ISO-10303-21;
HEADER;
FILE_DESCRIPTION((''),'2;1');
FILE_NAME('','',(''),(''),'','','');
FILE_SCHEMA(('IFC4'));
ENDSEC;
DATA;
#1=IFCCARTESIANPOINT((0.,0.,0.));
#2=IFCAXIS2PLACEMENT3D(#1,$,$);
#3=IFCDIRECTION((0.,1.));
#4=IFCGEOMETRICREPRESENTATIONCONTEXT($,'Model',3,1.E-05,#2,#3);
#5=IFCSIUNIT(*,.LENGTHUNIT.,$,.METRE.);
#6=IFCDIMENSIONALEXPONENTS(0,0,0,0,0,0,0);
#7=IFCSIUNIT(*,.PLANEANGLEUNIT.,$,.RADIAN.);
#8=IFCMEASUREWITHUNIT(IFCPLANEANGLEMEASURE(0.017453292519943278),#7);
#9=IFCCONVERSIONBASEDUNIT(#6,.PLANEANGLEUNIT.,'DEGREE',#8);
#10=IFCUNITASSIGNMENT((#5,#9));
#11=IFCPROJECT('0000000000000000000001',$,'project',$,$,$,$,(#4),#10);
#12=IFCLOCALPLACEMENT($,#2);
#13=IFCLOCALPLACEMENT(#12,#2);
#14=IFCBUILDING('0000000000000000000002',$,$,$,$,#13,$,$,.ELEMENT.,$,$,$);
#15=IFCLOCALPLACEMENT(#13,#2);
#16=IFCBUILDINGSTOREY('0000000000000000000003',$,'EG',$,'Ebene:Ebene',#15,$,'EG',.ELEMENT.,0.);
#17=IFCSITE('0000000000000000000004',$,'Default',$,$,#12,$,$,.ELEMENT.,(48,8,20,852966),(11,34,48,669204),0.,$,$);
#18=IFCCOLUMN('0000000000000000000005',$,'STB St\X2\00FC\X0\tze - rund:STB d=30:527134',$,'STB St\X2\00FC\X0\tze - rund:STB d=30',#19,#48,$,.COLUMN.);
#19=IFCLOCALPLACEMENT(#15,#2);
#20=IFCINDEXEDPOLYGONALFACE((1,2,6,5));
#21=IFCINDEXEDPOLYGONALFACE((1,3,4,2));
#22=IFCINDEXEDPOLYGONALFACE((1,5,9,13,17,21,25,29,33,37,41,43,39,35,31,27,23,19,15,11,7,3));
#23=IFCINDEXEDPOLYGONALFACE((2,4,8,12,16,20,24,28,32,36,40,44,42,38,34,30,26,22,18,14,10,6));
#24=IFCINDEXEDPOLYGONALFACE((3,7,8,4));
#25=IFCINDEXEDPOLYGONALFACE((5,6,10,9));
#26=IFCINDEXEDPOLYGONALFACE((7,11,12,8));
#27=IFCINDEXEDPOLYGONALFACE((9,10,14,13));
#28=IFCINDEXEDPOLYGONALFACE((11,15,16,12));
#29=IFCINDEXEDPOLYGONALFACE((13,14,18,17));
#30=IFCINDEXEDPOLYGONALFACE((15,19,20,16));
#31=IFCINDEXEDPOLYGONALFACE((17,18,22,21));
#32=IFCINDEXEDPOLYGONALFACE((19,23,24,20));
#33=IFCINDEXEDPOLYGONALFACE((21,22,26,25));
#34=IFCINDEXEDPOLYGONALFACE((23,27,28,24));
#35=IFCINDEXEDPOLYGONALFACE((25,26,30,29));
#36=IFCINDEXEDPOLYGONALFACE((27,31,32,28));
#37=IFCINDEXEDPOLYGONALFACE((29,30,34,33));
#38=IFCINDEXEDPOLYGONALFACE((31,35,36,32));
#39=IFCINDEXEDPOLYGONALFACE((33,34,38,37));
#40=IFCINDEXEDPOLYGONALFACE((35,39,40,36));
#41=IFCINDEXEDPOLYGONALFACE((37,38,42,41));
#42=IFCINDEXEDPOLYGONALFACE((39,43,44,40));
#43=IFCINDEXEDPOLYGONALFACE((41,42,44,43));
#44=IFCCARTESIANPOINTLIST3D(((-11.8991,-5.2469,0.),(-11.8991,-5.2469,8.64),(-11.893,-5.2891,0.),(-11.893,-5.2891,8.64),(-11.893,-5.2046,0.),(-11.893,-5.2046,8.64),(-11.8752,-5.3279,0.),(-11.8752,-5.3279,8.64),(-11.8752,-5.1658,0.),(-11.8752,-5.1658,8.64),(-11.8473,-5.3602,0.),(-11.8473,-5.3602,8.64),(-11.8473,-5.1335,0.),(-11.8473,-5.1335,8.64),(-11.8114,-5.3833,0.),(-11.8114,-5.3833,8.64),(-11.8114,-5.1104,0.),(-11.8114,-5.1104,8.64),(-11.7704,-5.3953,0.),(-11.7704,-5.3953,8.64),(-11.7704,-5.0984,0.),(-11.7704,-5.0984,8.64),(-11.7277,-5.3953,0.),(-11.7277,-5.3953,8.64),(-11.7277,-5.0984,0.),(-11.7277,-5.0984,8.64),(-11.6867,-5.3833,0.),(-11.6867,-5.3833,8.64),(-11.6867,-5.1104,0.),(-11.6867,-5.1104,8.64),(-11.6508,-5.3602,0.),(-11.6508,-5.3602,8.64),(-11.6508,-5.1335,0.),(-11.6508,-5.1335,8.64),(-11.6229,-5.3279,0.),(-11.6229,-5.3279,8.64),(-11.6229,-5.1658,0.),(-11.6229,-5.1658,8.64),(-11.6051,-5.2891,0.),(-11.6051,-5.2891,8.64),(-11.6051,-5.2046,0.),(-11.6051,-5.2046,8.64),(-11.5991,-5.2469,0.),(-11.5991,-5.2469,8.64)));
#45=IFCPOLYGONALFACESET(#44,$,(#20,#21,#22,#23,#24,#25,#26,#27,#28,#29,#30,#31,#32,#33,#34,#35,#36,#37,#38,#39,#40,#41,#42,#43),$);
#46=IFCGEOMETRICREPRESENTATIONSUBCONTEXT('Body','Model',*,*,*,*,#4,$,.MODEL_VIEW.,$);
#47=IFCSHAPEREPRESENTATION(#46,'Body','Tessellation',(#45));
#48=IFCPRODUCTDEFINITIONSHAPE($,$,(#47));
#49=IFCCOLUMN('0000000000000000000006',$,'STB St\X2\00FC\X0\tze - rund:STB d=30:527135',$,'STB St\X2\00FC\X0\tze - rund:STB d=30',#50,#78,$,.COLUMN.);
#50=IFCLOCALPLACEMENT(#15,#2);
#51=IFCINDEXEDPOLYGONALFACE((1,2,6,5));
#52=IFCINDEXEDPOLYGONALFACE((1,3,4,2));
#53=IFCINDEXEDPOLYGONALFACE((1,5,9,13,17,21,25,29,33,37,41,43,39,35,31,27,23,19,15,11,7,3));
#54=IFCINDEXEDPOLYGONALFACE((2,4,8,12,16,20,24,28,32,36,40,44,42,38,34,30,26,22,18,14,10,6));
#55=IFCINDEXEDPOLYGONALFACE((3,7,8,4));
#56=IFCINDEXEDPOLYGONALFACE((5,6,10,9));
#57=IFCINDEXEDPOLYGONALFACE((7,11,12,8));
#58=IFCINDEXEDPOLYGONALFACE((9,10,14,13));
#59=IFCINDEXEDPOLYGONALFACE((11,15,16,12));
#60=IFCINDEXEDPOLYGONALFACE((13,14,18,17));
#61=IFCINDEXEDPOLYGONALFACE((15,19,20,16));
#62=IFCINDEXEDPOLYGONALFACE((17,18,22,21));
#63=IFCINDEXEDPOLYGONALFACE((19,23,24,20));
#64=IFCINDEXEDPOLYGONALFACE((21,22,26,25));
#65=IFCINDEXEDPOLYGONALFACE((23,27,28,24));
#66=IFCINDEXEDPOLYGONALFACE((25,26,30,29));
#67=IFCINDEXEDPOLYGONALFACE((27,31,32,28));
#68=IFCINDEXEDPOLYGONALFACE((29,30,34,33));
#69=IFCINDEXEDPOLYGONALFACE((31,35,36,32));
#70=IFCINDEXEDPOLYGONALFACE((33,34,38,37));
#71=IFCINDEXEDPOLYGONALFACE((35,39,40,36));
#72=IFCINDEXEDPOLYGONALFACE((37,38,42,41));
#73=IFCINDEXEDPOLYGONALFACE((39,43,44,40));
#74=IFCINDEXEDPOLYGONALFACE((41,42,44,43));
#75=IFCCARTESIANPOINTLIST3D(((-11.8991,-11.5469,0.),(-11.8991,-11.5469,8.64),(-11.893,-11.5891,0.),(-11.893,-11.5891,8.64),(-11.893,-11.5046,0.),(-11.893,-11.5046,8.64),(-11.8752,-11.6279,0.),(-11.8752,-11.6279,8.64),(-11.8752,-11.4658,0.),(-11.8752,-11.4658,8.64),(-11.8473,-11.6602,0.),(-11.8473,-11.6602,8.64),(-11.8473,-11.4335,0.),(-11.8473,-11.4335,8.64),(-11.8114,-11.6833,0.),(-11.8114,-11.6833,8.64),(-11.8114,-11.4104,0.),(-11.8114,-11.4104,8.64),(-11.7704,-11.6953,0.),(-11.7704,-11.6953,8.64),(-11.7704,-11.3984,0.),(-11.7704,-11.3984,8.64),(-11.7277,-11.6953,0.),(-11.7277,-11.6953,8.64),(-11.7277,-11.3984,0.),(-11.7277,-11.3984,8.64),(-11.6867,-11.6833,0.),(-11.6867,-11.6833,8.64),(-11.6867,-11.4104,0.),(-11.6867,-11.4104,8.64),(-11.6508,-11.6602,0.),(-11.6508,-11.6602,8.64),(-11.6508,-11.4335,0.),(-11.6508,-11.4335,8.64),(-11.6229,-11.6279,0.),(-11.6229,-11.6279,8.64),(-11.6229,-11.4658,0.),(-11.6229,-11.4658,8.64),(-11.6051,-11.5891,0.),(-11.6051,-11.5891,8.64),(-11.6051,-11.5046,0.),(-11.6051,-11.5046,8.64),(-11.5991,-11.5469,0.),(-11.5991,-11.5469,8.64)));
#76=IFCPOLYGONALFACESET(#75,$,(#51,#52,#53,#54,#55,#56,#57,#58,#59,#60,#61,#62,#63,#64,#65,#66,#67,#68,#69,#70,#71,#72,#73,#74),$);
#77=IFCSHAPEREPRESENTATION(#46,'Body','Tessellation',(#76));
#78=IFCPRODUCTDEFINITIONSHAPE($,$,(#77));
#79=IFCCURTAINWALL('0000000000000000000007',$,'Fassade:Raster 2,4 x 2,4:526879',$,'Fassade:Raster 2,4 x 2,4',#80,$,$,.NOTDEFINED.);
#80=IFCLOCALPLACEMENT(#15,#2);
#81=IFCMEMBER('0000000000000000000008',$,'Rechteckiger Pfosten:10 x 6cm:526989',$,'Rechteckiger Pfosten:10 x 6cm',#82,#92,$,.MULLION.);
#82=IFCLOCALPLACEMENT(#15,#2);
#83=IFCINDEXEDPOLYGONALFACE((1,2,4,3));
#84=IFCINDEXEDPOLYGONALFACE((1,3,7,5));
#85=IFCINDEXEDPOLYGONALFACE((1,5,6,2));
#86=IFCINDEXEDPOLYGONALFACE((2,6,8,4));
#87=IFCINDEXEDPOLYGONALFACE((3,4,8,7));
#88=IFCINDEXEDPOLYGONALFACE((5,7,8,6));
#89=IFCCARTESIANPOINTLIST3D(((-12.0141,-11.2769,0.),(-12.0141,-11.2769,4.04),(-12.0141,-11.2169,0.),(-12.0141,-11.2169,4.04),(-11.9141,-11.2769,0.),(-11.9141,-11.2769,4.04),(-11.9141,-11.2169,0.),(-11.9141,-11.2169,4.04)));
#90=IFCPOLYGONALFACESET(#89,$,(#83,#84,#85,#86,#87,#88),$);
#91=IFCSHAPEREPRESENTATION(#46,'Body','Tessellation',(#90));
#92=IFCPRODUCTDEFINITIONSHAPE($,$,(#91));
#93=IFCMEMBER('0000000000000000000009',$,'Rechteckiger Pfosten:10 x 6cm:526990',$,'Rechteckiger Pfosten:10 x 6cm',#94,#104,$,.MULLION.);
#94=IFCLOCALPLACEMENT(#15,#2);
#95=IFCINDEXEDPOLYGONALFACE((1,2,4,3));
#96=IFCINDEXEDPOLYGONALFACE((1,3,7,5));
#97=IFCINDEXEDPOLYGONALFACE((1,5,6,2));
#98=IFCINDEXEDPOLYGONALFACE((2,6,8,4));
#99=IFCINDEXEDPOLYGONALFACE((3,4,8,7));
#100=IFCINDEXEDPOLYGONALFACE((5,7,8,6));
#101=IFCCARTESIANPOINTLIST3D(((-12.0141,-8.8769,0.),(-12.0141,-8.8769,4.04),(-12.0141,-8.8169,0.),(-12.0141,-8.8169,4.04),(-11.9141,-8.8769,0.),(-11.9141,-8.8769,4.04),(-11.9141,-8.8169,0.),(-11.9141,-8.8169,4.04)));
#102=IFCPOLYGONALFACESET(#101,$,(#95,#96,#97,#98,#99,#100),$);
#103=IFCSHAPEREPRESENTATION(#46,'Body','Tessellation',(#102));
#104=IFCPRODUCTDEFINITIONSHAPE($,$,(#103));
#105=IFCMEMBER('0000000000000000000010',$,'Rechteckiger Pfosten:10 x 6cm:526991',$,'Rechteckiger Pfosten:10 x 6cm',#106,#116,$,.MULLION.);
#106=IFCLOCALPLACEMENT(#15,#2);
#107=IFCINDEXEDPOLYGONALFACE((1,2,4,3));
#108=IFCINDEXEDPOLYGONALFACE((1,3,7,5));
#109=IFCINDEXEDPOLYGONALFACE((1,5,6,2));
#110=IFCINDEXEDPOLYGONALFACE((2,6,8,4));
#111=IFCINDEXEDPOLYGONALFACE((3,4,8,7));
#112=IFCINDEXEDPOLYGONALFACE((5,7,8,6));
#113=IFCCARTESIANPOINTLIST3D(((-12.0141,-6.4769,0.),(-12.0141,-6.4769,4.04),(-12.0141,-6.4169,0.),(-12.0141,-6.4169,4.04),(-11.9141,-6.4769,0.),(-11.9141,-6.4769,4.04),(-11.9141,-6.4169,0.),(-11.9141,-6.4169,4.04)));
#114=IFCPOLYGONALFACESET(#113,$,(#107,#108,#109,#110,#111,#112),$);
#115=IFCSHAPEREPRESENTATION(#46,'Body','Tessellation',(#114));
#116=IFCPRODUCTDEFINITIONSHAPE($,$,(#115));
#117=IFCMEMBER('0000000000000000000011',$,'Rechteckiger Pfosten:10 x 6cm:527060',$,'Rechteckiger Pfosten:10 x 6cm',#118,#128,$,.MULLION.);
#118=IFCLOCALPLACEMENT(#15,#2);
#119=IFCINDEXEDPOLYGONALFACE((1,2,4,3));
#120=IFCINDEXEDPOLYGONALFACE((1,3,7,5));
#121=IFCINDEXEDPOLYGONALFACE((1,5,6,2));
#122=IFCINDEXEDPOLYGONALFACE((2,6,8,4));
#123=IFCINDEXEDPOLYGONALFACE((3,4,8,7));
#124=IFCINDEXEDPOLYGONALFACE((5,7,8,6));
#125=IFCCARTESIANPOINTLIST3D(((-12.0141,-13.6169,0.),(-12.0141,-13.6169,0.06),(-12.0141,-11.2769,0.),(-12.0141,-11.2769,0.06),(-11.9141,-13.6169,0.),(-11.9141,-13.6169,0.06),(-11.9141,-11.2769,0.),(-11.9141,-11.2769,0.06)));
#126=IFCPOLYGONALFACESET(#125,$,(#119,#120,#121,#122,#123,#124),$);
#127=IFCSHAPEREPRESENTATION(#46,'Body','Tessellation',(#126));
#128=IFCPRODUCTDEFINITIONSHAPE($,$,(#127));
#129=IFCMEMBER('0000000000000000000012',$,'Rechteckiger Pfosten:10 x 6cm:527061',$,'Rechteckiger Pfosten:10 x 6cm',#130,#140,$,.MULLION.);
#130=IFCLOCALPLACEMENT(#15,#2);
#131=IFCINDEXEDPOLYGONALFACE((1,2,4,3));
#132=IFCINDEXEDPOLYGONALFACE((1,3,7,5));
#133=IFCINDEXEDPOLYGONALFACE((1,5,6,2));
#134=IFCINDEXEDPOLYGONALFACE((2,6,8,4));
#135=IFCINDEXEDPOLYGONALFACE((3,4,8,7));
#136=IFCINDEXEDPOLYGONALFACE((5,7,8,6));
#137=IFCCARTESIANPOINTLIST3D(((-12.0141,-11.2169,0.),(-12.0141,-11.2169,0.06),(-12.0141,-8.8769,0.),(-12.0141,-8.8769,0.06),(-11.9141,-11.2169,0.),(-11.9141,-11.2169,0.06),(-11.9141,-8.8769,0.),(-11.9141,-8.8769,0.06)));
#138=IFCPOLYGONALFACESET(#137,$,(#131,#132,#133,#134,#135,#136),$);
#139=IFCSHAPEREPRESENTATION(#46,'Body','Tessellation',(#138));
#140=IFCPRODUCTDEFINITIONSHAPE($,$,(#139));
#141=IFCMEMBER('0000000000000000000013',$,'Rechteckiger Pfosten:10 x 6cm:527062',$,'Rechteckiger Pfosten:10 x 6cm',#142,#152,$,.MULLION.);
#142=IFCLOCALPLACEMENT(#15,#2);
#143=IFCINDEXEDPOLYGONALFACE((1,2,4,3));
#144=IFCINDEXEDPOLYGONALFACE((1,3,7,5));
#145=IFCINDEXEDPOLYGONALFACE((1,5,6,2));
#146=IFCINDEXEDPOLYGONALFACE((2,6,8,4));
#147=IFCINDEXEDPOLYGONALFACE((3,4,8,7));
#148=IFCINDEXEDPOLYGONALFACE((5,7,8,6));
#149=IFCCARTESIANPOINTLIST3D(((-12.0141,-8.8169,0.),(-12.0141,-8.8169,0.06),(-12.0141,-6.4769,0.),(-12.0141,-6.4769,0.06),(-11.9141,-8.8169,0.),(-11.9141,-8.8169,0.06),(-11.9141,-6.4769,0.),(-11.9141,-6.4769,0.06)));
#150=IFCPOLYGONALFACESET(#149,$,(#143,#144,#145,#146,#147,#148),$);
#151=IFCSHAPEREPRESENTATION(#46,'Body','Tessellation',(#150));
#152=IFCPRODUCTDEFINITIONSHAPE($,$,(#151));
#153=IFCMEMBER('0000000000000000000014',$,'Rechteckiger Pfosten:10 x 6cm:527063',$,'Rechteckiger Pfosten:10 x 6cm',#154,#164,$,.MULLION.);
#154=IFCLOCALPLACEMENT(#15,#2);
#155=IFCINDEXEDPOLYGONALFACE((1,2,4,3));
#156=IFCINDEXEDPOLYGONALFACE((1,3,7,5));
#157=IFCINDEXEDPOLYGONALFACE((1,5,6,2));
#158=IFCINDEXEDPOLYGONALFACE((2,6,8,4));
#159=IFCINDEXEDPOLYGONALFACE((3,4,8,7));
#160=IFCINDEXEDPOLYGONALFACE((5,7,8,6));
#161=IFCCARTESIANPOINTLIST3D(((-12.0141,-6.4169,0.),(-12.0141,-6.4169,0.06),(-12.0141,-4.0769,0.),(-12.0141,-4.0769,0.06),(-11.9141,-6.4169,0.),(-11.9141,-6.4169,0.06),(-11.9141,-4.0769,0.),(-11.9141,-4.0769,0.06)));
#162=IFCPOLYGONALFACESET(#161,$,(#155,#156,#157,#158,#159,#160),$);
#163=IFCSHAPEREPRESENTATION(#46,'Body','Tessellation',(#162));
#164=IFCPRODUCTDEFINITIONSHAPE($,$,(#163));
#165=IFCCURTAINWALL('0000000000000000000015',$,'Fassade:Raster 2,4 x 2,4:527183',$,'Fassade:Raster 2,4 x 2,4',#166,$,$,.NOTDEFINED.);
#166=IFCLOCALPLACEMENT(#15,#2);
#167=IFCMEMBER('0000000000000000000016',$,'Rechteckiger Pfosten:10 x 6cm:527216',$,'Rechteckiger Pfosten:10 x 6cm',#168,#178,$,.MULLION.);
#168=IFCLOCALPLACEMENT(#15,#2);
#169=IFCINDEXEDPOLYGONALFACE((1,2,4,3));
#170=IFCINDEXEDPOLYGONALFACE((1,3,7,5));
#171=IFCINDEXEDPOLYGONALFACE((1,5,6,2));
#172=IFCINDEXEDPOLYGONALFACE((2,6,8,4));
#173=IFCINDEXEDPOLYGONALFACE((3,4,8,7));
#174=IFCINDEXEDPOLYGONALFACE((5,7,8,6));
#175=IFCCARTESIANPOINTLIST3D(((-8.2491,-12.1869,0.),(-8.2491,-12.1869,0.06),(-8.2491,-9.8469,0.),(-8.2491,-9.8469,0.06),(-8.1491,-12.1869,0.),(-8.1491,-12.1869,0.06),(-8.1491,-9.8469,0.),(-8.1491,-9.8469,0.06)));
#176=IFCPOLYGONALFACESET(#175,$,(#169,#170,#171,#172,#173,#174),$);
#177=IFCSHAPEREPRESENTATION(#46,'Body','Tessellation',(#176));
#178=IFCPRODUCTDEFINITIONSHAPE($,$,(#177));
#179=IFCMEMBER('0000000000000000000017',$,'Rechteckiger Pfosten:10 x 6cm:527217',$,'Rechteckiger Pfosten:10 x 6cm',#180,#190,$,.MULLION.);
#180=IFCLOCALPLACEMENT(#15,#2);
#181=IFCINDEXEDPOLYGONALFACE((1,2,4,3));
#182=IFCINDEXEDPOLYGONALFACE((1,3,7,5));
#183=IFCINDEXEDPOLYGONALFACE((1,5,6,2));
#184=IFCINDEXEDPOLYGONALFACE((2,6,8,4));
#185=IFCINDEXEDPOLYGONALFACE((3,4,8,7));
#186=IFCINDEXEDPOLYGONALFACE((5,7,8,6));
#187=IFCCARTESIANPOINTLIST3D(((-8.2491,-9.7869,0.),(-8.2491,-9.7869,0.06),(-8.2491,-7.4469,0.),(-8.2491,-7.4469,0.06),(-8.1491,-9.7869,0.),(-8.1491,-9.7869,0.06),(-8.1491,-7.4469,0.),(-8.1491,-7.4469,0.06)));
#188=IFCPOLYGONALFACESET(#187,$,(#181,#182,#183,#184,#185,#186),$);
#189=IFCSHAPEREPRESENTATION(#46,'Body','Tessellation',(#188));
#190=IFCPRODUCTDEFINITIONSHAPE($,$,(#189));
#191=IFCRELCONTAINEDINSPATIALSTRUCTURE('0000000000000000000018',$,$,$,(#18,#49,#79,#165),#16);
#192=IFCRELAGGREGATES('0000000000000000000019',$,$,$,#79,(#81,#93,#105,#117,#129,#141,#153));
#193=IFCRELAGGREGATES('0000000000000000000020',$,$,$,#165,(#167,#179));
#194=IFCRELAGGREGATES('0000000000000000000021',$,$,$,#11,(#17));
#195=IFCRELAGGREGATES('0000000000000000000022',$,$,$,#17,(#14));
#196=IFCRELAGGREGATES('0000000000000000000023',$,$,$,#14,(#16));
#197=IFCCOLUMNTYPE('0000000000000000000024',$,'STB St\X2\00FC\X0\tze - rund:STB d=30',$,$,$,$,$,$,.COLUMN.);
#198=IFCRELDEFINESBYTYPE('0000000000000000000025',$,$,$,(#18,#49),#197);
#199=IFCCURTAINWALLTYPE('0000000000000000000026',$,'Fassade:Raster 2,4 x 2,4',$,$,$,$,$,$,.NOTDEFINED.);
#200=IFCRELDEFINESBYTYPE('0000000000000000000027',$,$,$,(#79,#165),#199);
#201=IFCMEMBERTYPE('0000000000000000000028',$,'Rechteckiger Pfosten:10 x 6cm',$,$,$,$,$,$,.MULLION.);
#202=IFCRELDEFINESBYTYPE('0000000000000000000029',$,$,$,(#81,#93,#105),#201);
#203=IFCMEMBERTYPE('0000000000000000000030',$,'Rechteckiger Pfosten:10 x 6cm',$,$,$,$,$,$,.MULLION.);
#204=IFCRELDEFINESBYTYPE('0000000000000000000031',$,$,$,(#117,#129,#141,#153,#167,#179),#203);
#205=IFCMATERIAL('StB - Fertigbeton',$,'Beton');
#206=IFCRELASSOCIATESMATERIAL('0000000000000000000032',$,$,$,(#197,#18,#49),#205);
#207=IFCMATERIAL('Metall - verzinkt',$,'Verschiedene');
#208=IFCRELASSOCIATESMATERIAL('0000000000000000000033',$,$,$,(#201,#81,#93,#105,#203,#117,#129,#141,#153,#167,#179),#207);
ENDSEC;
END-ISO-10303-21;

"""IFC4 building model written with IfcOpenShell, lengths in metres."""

from ifc_helpers import new_model, entity, si_unit, converted_unit, direction, frame, origin, place, context, subcontext, project, spatial, arc, indexed_curve, outline, extrude, source, transform, mapped, material, type_object, type_shapes, element, aggregate, save


model = new_model("IFC4")

# Units and contexts
model_context = context("Model", 3, precision=1e-05, world=origin(), true_north=direction((0.0, 1.0)))
body_context = subcontext(model_context, "Body", "Model", "MODEL_VIEW")
ifc_project = project(units=[si_unit("LENGTHUNIT", "METRE"), converted_unit("PLANEANGLEUNIT", "DEGREE", entity("IfcPlaneAngleMeasure", 0.017453292519943278), si_unit("PLANEANGLEUNIT", "RADIAN"), dimensions=[0, 0, 0, 0, 0, 0, 0])], contexts=[model_context])

# Site, building, storey
site_placement = place(None, origin())
site = spatial("IfcSite", under=ifc_project, at=site_placement, Name="Default", CompositionType="ELEMENT", RefLatitude=(48, 8, 20, 852966), RefLongitude=(11, 34, 48, 669204), RefElevation=0.0)
building_placement = place(site_placement, origin())
building = spatial("IfcBuilding", under=site, at=building_placement, CompositionType="ELEMENT")
storey_placement = place(building_placement, origin())
storey = spatial("IfcBuildingStorey", under=building, at=storey_placement, Name="EG", ObjectType="Ebene:Ebene", LongName="EG", CompositionType="ELEMENT", Elevation=0.0)

# Columns
ifc_material_1 = material(Name="StB - Fertigbeton", Category="Beton")
column_type = type_object("IfcColumnType", Name="STB Stütze - rund:STB d=30", PredefinedType="COLUMN", material=ifc_material_1)
shared_shape_1 = source(origin(), body_context, "Body", "SweptSolid", [
    extrude(outline(indexed_curve([(-0.15, 0.0), (0.0, -0.15), (0.15, 0.0), (0.0, 0.15)], segments=[arc(1, 2, 3), arc(3, 4, 1)], self_intersect=False)), origin(), (0.0, 0.0, 1.0), 8.64),
])
type_shapes(column_type, [shared_shape_1])
for number, where, z_axis, x_axis, name in (
    (1, (-11.7491, -5.2469, 0.0), (0.0, 0.0, 1.0), (-1.0, 0.0, 0.0), "STB Stütze - rund:STB d=30:527134"),
    (2, (-11.7491, -11.5469, 0.0), (0.0, 0.0, 1.0), (-1.0, 0.0, 0.0), "STB Stütze - rund:STB d=30:527135"),
):
    element("IfcColumn", number, at=place(storey_placement, frame(where, z_axis=z_axis, x_axis=x_axis)), inside=storey, type_object=column_type, material=ifc_material_1, Name=name, ObjectType="STB Stütze - rund:STB d=30", PredefinedType="COLUMN", context=body_context, shape_type="MappedRepresentation", body=[
        mapped(shared_shape_1, transform((0.0, 0.0, 0.0), scale=1.0)),
    ])

# Curtain walls, members
curtain_wall_type = type_object("IfcCurtainWallType", Name="Fassade:Raster 2,4 x 2,4", PredefinedType="NOTDEFINED")
curtain_wall_1_placement = place(storey_placement, origin())
curtain_wall_1 = element("IfcCurtainWall", 3, at=curtain_wall_1_placement, inside=storey, type_object=curtain_wall_type, Name="Fassade:Raster 2,4 x 2,4:526879", ObjectType="Fassade:Raster 2,4 x 2,4", PredefinedType="NOTDEFINED")
ifc_material_2 = material(Name="Metall - verzinkt", Category="Verschiedene")
member_type_1 = type_object("IfcMemberType", Name="Rechteckiger Pfosten:10 x 6cm", PredefinedType="MULLION", material=ifc_material_2)
shared_shape_2 = source(origin(), body_context, "Body", "SweptSolid", [
    extrude(outline(indexed_curve([(-0.03, -0.05), (0.03, -0.05), (0.03, 0.05), (-0.03, 0.05), (-0.03, -0.05)], self_intersect=False)), frame((0.0, 0.0, -4.04), z_axis=(0.0, 0.0, 1.0), x_axis=(-1.0, 0.0, 0.0)), (0.0, 0.0, 1.0), 4.04),
])
type_shapes(member_type_1, [shared_shape_2])
member_1_placement = place(curtain_wall_1_placement, frame((-11.9641, -11.2469, 0.0), z_axis=(0.0, 0.0, -1.0), x_axis=(0.0, 1.0, 0.0)))
member_1 = element("IfcMember", 4, at=member_1_placement, type_object=member_type_1, material=ifc_material_2, Name="Rechteckiger Pfosten:10 x 6cm:526989", ObjectType="Rechteckiger Pfosten:10 x 6cm", PredefinedType="MULLION", context=body_context, shape_type="MappedRepresentation", body=[
    mapped(shared_shape_2, transform((0.0, 0.0, 0.0), scale=1.0)),
])
member_2_placement = place(curtain_wall_1_placement, frame((-11.9641, -8.8469, 0.0), z_axis=(0.0, 0.0, -1.0), x_axis=(0.0, 1.0, 0.0)))
member_2 = element("IfcMember", 5, at=member_2_placement, type_object=member_type_1, material=ifc_material_2, Name="Rechteckiger Pfosten:10 x 6cm:526990", ObjectType="Rechteckiger Pfosten:10 x 6cm", PredefinedType="MULLION", context=body_context, shape_type="MappedRepresentation", body=[
    mapped(shared_shape_2, transform((0.0, 0.0, 0.0), scale=1.0)),
])
member_3_placement = place(curtain_wall_1_placement, frame((-11.9641, -6.4469, 0.0), z_axis=(0.0, 0.0, -1.0), x_axis=(0.0, 1.0, 0.0)))
member_3 = element("IfcMember", 6, at=member_3_placement, type_object=member_type_1, material=ifc_material_2, Name="Rechteckiger Pfosten:10 x 6cm:526991", ObjectType="Rechteckiger Pfosten:10 x 6cm", PredefinedType="MULLION", context=body_context, shape_type="MappedRepresentation", body=[
    mapped(shared_shape_2, transform((0.0, 0.0, 0.0), scale=1.0)),
])
member_type_2 = type_object("IfcMemberType", Name="Rechteckiger Pfosten:10 x 6cm", PredefinedType="MULLION", material=ifc_material_2)
shared_shape_3 = source(origin(), body_context, "Body", "SweptSolid", [
    extrude(outline(indexed_curve([(-0.03, -0.05), (0.03, -0.05), (0.03, 0.05), (-0.03, 0.05), (-0.03, -0.05)], self_intersect=False)), frame((-0.03, 0.0, -2.34), z_axis=(0.0, 0.0, 1.0), x_axis=(-1.0, 0.0, 0.0)), (0.0, 0.0, 1.0), 2.34),
])
type_shapes(member_type_2, [shared_shape_3])
member_4_placement = place(curtain_wall_1_placement, frame((-11.9641, -13.6169, 0.0), z_axis=(0.0, -1.0, 0.0), x_axis=(0.0, 0.0, -1.0)))
member_4 = element("IfcMember", 7, at=member_4_placement, type_object=member_type_2, material=ifc_material_2, Name="Rechteckiger Pfosten:10 x 6cm:527060", ObjectType="Rechteckiger Pfosten:10 x 6cm", PredefinedType="MULLION", context=body_context, shape_type="MappedRepresentation", body=[
    mapped(shared_shape_3, transform((0.0, 0.0, 0.0), scale=1.0)),
])
member_5_placement = place(curtain_wall_1_placement, frame((-11.9641, -11.2169, 0.0), z_axis=(0.0, -1.0, 0.0), x_axis=(0.0, 0.0, -1.0)))
member_5 = element("IfcMember", 8, at=member_5_placement, type_object=member_type_2, material=ifc_material_2, Name="Rechteckiger Pfosten:10 x 6cm:527061", ObjectType="Rechteckiger Pfosten:10 x 6cm", PredefinedType="MULLION", context=body_context, shape_type="MappedRepresentation", body=[
    mapped(shared_shape_3, transform((0.0, 0.0, 0.0), scale=1.0)),
])
member_6_placement = place(curtain_wall_1_placement, frame((-11.9641, -8.8169, 0.0), z_axis=(0.0, -1.0, 0.0), x_axis=(0.0, 0.0, -1.0)))
member_6 = element("IfcMember", 9, at=member_6_placement, type_object=member_type_2, material=ifc_material_2, Name="Rechteckiger Pfosten:10 x 6cm:527062", ObjectType="Rechteckiger Pfosten:10 x 6cm", PredefinedType="MULLION", context=body_context, shape_type="MappedRepresentation", body=[
    mapped(shared_shape_3, transform((0.0, 0.0, 0.0), scale=1.0)),
])
member_7_placement = place(curtain_wall_1_placement, frame((-11.9641, -6.4169, 0.0), z_axis=(0.0, -1.0, 0.0), x_axis=(0.0, 0.0, -1.0)))
member_7 = element("IfcMember", 10, at=member_7_placement, type_object=member_type_2, material=ifc_material_2, Name="Rechteckiger Pfosten:10 x 6cm:527063", ObjectType="Rechteckiger Pfosten:10 x 6cm", PredefinedType="MULLION", context=body_context, shape_type="MappedRepresentation", body=[
    mapped(shared_shape_3, transform((0.0, 0.0, 0.0), scale=1.0)),
])
curtain_wall_2_placement = place(storey_placement, origin())
curtain_wall_2 = element("IfcCurtainWall", 11, at=curtain_wall_2_placement, inside=storey, type_object=curtain_wall_type, Name="Fassade:Raster 2,4 x 2,4:527183", ObjectType="Fassade:Raster 2,4 x 2,4", PredefinedType="NOTDEFINED")
member_8_placement = place(curtain_wall_2_placement, frame((-8.1991, -12.1869, 0.0), z_axis=(0.0, -1.0, 0.0), x_axis=(0.0, 0.0, -1.0)))
member_8 = element("IfcMember", 12, at=member_8_placement, type_object=member_type_2, material=ifc_material_2, Name="Rechteckiger Pfosten:10 x 6cm:527216", ObjectType="Rechteckiger Pfosten:10 x 6cm", PredefinedType="MULLION", context=body_context, shape_type="MappedRepresentation", body=[
    mapped(shared_shape_3, transform((0.0, 0.0, 0.0), scale=1.0)),
])
member_9_placement = place(curtain_wall_2_placement, frame((-8.1991, -9.7869, 0.0), z_axis=(0.0, -1.0, 0.0), x_axis=(0.0, 0.0, -1.0)))
member_9 = element("IfcMember", 13, at=member_9_placement, type_object=member_type_2, material=ifc_material_2, Name="Rechteckiger Pfosten:10 x 6cm:527217", ObjectType="Rechteckiger Pfosten:10 x 6cm", PredefinedType="MULLION", context=body_context, shape_type="MappedRepresentation", body=[
    mapped(shared_shape_3, transform((0.0, 0.0, 0.0), scale=1.0)),
])

aggregate(curtain_wall_1, [member_1, member_2, member_3, member_4, member_5, member_6, member_7])
aggregate(curtain_wall_2, [member_8, member_9])

save(model, "model.ifc")
